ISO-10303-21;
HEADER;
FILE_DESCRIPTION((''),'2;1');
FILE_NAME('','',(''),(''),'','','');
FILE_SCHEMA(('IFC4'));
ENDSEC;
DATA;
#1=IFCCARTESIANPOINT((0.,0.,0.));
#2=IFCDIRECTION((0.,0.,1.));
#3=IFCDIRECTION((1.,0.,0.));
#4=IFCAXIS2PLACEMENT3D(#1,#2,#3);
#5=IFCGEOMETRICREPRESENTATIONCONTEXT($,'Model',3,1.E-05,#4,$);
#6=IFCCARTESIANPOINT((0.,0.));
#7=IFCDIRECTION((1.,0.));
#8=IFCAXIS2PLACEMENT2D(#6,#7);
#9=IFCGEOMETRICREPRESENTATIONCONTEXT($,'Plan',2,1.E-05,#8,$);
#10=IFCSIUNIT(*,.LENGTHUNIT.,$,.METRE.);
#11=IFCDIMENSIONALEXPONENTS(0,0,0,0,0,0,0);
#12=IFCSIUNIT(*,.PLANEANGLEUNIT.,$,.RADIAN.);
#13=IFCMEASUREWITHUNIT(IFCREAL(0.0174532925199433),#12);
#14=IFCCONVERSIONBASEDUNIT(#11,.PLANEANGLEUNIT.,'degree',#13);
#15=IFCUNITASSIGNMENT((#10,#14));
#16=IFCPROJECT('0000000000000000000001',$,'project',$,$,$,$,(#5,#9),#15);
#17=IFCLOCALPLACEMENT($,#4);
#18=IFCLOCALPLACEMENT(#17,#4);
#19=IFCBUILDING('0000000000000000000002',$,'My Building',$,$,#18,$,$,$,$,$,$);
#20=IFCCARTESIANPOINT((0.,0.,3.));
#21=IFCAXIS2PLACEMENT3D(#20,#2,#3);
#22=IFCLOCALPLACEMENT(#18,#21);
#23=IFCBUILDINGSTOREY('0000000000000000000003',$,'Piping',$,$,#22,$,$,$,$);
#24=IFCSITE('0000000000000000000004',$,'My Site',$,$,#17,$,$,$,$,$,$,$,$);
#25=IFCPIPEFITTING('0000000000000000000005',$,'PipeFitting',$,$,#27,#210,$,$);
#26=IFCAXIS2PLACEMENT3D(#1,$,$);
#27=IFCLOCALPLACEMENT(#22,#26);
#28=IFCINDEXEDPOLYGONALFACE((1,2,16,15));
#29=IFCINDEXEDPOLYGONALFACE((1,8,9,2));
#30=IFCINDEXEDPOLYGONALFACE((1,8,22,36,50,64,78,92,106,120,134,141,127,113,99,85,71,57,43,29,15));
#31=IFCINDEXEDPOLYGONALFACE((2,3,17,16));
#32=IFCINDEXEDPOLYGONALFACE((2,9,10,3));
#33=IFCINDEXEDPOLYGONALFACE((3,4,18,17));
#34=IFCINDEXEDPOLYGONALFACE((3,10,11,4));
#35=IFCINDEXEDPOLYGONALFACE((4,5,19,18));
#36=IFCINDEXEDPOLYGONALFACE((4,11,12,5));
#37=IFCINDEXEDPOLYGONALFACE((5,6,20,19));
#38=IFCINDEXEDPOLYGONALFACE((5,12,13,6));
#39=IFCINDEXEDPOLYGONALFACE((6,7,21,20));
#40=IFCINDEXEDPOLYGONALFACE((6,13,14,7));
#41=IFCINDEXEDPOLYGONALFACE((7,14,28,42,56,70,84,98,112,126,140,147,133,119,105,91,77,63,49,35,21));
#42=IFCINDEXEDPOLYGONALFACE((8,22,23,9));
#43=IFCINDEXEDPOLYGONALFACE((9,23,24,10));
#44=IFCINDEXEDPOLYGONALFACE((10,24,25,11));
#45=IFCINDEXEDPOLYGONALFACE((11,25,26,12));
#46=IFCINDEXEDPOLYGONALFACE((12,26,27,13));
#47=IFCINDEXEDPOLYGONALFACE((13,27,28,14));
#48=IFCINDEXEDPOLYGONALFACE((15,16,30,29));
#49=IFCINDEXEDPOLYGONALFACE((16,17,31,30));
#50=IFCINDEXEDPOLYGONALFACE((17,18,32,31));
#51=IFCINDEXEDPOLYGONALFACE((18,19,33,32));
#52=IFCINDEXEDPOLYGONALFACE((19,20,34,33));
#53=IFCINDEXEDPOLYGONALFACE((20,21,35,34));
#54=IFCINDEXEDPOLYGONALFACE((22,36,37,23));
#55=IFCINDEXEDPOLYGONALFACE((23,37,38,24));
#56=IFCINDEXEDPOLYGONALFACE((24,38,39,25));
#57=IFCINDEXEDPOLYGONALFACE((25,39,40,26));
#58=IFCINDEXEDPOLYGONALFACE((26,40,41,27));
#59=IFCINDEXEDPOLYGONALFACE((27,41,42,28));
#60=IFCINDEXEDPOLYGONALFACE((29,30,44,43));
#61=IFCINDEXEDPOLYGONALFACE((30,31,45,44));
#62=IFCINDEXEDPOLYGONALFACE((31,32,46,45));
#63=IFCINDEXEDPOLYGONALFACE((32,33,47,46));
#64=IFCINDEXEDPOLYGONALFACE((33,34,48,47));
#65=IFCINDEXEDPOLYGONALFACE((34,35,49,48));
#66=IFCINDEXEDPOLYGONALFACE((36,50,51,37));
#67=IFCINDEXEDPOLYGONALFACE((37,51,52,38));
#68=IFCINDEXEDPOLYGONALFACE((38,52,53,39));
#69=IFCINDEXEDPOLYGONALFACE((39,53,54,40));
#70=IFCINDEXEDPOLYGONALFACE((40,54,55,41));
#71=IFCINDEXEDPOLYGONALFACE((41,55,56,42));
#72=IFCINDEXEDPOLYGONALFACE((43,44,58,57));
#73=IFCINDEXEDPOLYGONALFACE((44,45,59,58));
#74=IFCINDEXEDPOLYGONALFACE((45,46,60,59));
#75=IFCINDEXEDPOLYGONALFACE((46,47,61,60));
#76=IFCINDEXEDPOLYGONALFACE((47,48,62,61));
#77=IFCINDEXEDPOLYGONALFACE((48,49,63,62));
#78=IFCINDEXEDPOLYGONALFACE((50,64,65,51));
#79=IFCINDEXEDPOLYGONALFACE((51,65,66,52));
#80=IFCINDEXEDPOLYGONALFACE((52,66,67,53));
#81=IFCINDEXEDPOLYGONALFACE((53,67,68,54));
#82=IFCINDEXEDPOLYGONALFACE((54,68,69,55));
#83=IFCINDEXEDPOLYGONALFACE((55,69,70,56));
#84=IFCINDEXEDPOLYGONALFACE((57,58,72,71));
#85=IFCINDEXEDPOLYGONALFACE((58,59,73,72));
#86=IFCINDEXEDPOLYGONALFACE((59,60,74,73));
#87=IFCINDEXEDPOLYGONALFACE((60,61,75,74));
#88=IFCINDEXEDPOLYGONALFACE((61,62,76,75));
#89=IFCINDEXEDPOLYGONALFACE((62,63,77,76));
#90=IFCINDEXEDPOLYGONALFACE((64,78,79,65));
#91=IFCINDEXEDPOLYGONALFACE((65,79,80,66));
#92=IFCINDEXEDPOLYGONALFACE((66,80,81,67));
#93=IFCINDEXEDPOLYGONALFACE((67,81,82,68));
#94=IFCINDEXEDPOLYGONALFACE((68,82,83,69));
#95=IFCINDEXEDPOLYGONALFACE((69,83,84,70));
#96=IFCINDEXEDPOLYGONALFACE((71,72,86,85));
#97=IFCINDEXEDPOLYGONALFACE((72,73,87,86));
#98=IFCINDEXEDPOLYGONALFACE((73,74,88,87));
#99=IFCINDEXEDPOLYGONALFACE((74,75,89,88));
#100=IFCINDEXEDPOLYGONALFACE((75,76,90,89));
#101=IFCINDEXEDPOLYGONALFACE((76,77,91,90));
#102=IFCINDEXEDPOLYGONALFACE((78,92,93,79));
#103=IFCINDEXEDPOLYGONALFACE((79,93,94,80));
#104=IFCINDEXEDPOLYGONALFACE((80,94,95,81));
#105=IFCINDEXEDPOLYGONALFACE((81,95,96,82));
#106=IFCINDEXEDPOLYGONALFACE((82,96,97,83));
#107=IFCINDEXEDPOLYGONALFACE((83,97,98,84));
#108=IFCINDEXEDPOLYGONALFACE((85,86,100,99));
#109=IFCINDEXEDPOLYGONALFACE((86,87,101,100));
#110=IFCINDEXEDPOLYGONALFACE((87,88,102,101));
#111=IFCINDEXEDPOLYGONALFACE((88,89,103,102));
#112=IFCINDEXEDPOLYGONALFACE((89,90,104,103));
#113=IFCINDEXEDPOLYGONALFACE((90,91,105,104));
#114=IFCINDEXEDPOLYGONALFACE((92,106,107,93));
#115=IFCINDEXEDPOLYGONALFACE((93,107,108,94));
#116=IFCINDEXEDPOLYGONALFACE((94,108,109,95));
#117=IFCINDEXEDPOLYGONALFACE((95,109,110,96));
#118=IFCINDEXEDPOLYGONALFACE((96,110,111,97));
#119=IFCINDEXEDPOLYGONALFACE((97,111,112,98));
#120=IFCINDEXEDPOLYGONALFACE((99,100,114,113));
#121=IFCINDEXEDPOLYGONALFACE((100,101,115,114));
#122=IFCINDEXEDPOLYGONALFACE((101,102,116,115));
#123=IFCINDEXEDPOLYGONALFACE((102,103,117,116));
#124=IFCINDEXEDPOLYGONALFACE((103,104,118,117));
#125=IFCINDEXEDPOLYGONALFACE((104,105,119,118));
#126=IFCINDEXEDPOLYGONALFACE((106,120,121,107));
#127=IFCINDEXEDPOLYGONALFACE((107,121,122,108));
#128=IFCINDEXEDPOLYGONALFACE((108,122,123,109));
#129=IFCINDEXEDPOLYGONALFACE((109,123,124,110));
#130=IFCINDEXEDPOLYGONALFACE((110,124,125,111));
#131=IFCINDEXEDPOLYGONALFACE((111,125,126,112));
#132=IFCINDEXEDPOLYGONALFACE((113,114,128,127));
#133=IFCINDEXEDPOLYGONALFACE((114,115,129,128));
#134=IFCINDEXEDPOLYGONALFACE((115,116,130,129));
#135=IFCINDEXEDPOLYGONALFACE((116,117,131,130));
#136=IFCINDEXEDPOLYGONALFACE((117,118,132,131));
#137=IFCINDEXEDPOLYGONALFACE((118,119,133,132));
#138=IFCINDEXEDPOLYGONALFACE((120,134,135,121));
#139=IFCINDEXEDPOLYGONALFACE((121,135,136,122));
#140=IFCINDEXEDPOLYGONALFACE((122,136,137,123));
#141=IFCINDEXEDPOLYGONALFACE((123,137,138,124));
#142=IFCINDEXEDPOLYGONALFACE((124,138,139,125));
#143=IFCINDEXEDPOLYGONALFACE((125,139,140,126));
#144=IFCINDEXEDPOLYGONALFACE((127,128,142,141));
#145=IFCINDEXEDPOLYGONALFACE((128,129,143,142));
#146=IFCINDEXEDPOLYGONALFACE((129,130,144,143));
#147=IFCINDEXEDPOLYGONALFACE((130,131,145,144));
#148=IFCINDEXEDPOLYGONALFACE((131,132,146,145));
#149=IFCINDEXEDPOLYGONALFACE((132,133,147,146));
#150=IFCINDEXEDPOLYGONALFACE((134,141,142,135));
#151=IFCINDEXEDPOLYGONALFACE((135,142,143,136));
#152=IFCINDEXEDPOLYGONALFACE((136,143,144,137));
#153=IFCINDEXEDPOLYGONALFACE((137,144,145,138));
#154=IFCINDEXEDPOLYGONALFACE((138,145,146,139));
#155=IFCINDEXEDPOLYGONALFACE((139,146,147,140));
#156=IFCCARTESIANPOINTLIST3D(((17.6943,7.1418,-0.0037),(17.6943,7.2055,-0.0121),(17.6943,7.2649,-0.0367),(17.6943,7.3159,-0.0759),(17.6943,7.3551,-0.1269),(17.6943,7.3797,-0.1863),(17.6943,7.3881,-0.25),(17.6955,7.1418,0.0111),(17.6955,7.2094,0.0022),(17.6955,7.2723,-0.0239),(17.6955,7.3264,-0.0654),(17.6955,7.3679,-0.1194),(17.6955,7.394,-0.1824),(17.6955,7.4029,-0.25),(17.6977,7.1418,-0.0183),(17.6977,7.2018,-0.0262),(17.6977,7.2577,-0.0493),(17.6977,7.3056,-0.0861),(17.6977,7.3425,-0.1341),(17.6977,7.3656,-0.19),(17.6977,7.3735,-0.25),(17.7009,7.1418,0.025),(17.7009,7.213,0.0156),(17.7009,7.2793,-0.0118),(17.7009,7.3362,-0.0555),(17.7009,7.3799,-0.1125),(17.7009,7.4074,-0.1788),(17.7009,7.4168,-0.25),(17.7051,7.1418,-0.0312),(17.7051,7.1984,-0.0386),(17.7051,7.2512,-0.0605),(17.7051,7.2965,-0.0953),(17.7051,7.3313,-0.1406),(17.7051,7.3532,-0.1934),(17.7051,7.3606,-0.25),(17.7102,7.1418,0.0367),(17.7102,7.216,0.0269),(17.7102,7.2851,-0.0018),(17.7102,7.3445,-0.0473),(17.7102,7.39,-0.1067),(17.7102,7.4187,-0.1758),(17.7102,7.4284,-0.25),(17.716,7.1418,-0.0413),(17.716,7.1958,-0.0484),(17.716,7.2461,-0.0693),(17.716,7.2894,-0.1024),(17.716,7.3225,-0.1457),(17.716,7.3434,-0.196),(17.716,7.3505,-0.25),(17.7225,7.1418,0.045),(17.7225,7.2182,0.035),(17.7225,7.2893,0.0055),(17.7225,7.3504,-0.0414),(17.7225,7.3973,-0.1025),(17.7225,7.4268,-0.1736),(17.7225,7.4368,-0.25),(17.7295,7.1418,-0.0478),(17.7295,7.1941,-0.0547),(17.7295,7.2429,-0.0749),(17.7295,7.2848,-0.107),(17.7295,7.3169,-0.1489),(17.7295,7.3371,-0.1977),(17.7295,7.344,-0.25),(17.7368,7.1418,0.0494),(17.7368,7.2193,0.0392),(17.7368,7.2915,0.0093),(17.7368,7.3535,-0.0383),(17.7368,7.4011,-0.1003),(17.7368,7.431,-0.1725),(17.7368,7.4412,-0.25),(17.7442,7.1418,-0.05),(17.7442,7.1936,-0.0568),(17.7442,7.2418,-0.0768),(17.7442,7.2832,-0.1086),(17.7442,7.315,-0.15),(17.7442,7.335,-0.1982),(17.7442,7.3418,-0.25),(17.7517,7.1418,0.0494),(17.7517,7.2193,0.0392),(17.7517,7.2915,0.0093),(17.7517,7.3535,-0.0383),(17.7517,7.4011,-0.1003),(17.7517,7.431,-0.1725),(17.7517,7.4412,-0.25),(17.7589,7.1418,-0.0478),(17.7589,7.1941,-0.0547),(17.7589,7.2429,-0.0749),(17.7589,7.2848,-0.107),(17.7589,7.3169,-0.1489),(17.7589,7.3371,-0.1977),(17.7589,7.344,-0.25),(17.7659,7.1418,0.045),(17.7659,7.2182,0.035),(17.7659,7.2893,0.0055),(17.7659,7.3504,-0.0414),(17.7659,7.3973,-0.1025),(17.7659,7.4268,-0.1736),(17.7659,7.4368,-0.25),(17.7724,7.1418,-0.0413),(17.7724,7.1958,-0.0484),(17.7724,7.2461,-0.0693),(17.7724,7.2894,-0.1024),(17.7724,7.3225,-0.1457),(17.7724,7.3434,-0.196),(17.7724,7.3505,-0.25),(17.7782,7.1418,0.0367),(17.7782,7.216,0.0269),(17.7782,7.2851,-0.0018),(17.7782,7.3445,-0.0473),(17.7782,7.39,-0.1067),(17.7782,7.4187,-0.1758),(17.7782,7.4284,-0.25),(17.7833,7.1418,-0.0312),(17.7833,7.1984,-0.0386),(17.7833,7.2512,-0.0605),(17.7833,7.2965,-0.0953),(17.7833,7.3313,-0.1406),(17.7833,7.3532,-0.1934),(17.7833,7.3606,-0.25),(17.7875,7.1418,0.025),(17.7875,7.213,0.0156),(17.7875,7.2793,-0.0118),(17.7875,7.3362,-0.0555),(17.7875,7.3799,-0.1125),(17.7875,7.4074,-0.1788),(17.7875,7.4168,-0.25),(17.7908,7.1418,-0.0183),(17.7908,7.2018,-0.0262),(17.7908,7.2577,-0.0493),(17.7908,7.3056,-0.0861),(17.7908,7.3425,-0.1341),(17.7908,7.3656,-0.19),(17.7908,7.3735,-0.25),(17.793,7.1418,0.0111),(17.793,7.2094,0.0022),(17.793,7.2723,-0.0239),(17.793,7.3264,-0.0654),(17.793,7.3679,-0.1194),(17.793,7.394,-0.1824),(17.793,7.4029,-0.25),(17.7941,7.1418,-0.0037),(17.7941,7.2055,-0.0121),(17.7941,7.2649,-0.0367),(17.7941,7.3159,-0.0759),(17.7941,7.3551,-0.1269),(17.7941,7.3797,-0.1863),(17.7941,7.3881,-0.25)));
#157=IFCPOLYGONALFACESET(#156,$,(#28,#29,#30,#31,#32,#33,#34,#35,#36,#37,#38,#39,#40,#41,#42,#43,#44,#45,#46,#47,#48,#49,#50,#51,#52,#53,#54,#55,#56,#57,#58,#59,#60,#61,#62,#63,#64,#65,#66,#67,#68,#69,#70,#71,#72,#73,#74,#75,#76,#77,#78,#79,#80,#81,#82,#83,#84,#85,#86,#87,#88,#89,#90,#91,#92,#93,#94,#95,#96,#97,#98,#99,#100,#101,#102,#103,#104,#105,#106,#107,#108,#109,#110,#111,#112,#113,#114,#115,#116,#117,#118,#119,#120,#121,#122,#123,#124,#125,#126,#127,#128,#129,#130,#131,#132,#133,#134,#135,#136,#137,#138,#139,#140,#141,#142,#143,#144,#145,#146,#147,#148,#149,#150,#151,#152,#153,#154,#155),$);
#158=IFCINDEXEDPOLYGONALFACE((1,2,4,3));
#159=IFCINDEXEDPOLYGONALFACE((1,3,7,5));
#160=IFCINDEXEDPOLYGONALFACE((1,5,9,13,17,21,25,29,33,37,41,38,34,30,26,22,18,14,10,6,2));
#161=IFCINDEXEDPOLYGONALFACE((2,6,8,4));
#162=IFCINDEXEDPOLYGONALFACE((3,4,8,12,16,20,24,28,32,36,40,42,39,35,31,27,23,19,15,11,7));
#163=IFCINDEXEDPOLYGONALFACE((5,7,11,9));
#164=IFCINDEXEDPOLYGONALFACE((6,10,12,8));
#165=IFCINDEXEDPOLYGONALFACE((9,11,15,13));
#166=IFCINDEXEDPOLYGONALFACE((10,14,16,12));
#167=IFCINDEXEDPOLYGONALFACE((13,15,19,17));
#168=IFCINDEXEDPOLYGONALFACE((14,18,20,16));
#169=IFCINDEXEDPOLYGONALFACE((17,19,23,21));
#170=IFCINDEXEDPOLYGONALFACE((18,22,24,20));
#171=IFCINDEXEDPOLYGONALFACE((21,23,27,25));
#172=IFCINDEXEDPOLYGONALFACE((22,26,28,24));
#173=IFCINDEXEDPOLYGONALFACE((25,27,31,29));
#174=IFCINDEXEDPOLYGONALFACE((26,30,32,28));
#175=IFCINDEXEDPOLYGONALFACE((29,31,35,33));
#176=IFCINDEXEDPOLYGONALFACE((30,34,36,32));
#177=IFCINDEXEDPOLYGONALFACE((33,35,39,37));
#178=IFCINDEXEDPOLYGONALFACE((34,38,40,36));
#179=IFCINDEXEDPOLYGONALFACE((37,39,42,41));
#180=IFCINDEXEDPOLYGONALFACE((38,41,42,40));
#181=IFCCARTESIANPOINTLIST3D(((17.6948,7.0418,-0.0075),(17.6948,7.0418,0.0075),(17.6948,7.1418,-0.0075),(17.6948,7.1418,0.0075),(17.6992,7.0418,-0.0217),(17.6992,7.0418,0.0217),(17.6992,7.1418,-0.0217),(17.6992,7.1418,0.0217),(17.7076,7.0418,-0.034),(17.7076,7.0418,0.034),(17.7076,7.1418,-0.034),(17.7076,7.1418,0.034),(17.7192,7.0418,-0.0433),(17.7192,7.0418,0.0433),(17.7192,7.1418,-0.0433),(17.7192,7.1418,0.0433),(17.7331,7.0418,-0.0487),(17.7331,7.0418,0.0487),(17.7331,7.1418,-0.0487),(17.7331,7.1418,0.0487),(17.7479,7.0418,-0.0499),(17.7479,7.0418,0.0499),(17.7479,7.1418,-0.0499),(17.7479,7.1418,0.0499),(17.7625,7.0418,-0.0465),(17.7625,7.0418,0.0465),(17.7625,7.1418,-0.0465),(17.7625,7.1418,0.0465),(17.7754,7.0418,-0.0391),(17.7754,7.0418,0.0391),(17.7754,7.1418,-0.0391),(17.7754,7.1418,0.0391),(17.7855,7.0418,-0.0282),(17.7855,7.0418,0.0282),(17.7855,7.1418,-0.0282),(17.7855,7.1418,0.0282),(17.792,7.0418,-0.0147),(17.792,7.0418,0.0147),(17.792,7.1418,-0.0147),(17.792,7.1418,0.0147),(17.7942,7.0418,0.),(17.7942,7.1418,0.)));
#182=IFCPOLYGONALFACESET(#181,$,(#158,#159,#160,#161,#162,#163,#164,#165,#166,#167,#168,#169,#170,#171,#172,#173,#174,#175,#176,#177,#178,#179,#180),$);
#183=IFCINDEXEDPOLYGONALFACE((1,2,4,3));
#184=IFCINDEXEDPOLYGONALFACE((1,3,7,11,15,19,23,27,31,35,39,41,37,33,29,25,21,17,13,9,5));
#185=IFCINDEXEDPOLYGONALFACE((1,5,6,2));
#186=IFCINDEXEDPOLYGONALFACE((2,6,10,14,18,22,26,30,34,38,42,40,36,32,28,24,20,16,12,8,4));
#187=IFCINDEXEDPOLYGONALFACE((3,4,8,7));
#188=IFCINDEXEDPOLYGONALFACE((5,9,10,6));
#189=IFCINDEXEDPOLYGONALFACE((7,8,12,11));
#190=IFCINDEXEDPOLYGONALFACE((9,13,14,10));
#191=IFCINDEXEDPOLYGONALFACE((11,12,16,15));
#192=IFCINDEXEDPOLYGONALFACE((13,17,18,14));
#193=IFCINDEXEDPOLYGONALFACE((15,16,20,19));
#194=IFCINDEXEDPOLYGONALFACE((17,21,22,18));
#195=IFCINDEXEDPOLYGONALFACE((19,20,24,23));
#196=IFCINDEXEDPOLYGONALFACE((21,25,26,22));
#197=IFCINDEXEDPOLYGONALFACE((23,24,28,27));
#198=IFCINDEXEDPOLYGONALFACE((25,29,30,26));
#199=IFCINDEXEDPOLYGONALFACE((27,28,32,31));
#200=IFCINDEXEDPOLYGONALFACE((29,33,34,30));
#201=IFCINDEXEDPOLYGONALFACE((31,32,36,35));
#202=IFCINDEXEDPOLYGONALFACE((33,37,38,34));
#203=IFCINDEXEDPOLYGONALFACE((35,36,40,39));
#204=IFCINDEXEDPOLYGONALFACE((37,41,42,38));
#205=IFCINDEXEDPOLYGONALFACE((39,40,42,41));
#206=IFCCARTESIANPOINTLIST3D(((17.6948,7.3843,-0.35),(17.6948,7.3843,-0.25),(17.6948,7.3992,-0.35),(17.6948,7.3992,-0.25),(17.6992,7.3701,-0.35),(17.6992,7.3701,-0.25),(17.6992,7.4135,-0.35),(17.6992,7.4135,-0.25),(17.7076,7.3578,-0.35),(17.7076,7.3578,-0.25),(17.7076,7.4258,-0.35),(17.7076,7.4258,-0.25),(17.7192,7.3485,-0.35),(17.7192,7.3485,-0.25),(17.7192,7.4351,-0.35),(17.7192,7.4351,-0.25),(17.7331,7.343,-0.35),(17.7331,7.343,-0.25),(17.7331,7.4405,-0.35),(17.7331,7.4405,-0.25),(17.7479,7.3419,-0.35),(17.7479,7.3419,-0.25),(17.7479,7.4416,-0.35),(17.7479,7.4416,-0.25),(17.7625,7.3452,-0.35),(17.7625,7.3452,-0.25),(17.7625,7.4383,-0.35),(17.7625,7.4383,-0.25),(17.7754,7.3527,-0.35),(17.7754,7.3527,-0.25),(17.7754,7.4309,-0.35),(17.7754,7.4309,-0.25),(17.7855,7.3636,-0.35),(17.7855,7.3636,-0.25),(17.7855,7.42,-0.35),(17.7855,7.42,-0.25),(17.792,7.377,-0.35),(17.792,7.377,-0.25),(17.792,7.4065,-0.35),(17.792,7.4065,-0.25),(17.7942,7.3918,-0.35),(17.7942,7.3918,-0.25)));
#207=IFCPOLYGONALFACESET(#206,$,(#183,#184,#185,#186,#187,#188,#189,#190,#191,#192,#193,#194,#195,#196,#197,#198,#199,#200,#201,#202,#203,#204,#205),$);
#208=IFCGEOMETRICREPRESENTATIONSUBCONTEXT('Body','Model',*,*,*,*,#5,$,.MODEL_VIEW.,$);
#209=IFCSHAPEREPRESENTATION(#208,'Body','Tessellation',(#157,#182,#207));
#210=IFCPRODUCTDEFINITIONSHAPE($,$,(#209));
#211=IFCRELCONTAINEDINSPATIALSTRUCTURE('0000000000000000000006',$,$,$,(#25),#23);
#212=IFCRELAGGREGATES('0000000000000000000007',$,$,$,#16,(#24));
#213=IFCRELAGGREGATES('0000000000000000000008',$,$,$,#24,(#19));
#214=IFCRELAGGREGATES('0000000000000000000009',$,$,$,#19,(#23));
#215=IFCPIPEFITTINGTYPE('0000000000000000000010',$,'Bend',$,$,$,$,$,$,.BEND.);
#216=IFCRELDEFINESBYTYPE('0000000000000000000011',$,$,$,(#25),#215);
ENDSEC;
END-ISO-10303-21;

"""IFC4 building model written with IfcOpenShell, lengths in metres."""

from ifc_helpers import new_model, entity, si_unit, converted_unit, frame, origin_with_axes, origin_2d_with_axis, place, context, subcontext, project, spatial, circle, extrude, source, transform, mapped, type_object, type_shapes, element, save


model = new_model("IFC4")

# Units and contexts
model_context = context("Model", 3, precision=1e-05, world=origin_with_axes())
plan_context = context("Plan", 2, precision=1e-05, world=origin_2d_with_axis())
body_context = subcontext(model_context, "Body", "Model", "MODEL_VIEW")
ifc_project = project(units=[si_unit("LENGTHUNIT", "METRE"), converted_unit("PLANEANGLEUNIT", "degree", entity("IfcReal", 0.0174532925199433), si_unit("PLANEANGLEUNIT", "RADIAN"), dimensions=[0, 0, 0, 0, 0, 0, 0])], contexts=[model_context, plan_context])

# Site, building, storey
site_placement = place(None, origin_with_axes())
site = spatial("IfcSite", under=ifc_project, at=site_placement, Name="My Site")
building_placement = place(site_placement, origin_with_axes())
building = spatial("IfcBuilding", under=site, at=building_placement, Name="My Building")
storey_placement = place(building_placement, frame((0.0, 0.0, 3.0), z_axis=(0.0, 0.0, 1.0), x_axis=(1.0, 0.0, 0.0)))
storey = spatial("IfcBuildingStorey", under=building, at=storey_placement, Name="Piping")

# Pipe fitting
pipe_fitting_type = type_object("IfcPipeFittingType", Name="Bend", PredefinedType="BEND")
shared_shape = source(origin_with_axes(), body_context, "Body", "SolidModel", [
    entity("IfcSweptDiskSolid", entity("IfcIndexedPolyCurve", entity("IfcCartesianPointList3D", [[0.0, 0.0, -0.1], [0.0, -0.0732, -0.2768], [0.0, -0.25, -0.35]]), [entity("IfcArcIndex", [1, 2, 3])]), 0.05),
    extrude(circle(Radius=0.05), origin_with_axes(), (0.0, 0.0, -1.0), 0.1),
    extrude(circle(Radius=0.05), frame((0.0, -0.25, -0.35), z_axis=(0.0, -1.0, 0.0), x_axis=(1.0, 0.0, 0.0)), (0.0, 0.0, 1.0), 0.1),
])
type_shapes(pipe_fitting_type, [shared_shape])
for number, where, z_axis, x_axis, name in (
    (1, (17.7442, 7.0418, 0.0), (0.0, -1.0, 0.0), (1.0, 0.0, 0.0), "PipeFitting"),
):
    element("IfcPipeFitting", number, at=place(storey_placement, frame(where, z_axis=z_axis, x_axis=x_axis)), inside=storey, type_object=pipe_fitting_type, Name=name, context=body_context, shape_type="MappedRepresentation", body=[
        mapped(shared_shape, transform((0.0, 0.0, 0.0), x_axis=(1.0, 0.0, 0.0), y_axis=(0.0, 1.0, 0.0), z_axis=(0.0, 0.0, 1.0), scale=1.0)),
    ])

save(model, "model.ifc")
